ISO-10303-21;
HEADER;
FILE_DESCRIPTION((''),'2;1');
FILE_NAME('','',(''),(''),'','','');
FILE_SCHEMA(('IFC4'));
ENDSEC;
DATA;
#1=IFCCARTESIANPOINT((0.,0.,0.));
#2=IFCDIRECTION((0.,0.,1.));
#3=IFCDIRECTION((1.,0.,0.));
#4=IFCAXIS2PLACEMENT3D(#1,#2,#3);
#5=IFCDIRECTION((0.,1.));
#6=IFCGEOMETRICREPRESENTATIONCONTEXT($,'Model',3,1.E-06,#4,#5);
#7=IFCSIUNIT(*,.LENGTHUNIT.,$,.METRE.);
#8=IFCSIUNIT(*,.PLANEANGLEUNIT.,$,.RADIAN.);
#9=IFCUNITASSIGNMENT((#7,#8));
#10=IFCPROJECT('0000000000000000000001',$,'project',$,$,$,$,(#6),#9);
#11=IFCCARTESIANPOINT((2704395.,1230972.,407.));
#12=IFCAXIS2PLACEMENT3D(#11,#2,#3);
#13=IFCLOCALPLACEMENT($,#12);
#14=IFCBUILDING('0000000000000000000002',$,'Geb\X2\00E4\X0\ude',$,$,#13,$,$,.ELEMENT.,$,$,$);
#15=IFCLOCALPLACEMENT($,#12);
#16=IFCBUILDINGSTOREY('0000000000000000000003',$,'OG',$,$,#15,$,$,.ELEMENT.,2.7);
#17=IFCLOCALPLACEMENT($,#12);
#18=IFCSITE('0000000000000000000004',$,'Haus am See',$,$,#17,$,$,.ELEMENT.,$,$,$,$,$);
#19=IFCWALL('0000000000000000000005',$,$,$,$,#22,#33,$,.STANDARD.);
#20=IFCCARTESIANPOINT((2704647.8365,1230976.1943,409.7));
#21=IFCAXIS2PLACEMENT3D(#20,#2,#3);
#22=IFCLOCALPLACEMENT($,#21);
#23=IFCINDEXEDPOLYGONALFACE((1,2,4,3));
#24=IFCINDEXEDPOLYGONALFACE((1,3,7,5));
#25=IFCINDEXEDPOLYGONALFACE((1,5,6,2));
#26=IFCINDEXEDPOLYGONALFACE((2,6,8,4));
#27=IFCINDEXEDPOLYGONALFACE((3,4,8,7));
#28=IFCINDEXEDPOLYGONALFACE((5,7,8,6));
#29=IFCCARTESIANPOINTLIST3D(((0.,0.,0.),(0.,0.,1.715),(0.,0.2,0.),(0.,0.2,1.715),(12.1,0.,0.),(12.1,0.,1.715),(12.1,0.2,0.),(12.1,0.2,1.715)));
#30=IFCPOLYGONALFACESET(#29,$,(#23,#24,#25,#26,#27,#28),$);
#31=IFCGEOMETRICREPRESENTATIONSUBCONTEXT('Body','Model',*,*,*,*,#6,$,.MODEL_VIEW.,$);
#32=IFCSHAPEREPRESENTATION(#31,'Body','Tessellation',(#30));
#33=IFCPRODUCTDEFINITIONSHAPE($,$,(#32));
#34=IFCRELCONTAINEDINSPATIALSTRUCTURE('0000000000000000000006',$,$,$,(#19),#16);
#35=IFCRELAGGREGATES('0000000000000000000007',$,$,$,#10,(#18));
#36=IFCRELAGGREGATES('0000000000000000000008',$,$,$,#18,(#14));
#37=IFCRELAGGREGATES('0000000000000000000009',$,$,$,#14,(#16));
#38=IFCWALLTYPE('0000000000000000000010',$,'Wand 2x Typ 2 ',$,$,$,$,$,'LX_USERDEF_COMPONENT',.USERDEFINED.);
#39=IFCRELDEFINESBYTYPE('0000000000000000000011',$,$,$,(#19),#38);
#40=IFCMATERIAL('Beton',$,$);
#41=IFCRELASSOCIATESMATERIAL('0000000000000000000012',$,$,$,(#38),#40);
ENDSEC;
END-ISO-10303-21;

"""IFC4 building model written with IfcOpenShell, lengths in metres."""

from ifc_helpers import new_model, si_unit, direction, frame, origin_with_axes, place, context, subcontext, project, spatial, polyline, outline, extrude, material, type_object, element, save


model = new_model("IFC4")

# Units and contexts
model_context = context("Model", 3, precision=1e-06, world=origin_with_axes(), true_north=direction((0.0, 1.0)))
body_context = subcontext(model_context, "Body", "Model", "MODEL_VIEW")
ifc_project = project(units=[si_unit("LENGTHUNIT", "METRE"), si_unit("PLANEANGLEUNIT", "RADIAN")], contexts=[model_context])

# Site, building, storey
site_placement = place(None, frame((2704395.0, 1230972.0, 407.0), z_axis=(0.0, 0.0, 1.0), x_axis=(1.0, 0.0, 0.0)))
site = spatial("IfcSite", under=ifc_project, at=site_placement, Name="Haus am See", CompositionType="ELEMENT")
building_placement = place(None, frame((2704395.0, 1230972.0, 407.0), z_axis=(0.0, 0.0, 1.0), x_axis=(1.0, 0.0, 0.0)))
building = spatial("IfcBuilding", under=site, at=building_placement, Name="Gebäude", CompositionType="ELEMENT")
storey_placement = place(None, frame((2704395.0, 1230972.0, 407.0), z_axis=(0.0, 0.0, 1.0), x_axis=(1.0, 0.0, 0.0)))
storey = spatial("IfcBuildingStorey", under=building, at=storey_placement, Name="OG", CompositionType="ELEMENT", Elevation=2.7)

# Wall
ifc_material_1 = material(Name="Beton")
wall_type = type_object("IfcWallType", Name="Wand 2x Typ 2 ", ElementType="LX_USERDEF_COMPONENT", PredefinedType="USERDEFINED", material=ifc_material_1)
wall_1_placement = place(None, frame((2704647.8365, 1230976.1943, 409.7), z_axis=(0.0, 0.0, 1.0), x_axis=(1.0, 0.0, 0.0)))
element("IfcWall", 1, at=wall_1_placement, inside=storey, type_object=wall_type, PredefinedType="STANDARD", context=body_context, shape_type="SweptSolid", body=[
    extrude(outline(polyline([(0.0, 0.0, 0.0), (12.1, 0.0, 0.0), (12.1, 0.2, 0.0), (0.0, 0.2, 0.0), (0.0, 0.0, 0.0)])), origin_with_axes(), (0.0, 0.0, 1.0), 1.715),
])

save(model, "model.ifc")
